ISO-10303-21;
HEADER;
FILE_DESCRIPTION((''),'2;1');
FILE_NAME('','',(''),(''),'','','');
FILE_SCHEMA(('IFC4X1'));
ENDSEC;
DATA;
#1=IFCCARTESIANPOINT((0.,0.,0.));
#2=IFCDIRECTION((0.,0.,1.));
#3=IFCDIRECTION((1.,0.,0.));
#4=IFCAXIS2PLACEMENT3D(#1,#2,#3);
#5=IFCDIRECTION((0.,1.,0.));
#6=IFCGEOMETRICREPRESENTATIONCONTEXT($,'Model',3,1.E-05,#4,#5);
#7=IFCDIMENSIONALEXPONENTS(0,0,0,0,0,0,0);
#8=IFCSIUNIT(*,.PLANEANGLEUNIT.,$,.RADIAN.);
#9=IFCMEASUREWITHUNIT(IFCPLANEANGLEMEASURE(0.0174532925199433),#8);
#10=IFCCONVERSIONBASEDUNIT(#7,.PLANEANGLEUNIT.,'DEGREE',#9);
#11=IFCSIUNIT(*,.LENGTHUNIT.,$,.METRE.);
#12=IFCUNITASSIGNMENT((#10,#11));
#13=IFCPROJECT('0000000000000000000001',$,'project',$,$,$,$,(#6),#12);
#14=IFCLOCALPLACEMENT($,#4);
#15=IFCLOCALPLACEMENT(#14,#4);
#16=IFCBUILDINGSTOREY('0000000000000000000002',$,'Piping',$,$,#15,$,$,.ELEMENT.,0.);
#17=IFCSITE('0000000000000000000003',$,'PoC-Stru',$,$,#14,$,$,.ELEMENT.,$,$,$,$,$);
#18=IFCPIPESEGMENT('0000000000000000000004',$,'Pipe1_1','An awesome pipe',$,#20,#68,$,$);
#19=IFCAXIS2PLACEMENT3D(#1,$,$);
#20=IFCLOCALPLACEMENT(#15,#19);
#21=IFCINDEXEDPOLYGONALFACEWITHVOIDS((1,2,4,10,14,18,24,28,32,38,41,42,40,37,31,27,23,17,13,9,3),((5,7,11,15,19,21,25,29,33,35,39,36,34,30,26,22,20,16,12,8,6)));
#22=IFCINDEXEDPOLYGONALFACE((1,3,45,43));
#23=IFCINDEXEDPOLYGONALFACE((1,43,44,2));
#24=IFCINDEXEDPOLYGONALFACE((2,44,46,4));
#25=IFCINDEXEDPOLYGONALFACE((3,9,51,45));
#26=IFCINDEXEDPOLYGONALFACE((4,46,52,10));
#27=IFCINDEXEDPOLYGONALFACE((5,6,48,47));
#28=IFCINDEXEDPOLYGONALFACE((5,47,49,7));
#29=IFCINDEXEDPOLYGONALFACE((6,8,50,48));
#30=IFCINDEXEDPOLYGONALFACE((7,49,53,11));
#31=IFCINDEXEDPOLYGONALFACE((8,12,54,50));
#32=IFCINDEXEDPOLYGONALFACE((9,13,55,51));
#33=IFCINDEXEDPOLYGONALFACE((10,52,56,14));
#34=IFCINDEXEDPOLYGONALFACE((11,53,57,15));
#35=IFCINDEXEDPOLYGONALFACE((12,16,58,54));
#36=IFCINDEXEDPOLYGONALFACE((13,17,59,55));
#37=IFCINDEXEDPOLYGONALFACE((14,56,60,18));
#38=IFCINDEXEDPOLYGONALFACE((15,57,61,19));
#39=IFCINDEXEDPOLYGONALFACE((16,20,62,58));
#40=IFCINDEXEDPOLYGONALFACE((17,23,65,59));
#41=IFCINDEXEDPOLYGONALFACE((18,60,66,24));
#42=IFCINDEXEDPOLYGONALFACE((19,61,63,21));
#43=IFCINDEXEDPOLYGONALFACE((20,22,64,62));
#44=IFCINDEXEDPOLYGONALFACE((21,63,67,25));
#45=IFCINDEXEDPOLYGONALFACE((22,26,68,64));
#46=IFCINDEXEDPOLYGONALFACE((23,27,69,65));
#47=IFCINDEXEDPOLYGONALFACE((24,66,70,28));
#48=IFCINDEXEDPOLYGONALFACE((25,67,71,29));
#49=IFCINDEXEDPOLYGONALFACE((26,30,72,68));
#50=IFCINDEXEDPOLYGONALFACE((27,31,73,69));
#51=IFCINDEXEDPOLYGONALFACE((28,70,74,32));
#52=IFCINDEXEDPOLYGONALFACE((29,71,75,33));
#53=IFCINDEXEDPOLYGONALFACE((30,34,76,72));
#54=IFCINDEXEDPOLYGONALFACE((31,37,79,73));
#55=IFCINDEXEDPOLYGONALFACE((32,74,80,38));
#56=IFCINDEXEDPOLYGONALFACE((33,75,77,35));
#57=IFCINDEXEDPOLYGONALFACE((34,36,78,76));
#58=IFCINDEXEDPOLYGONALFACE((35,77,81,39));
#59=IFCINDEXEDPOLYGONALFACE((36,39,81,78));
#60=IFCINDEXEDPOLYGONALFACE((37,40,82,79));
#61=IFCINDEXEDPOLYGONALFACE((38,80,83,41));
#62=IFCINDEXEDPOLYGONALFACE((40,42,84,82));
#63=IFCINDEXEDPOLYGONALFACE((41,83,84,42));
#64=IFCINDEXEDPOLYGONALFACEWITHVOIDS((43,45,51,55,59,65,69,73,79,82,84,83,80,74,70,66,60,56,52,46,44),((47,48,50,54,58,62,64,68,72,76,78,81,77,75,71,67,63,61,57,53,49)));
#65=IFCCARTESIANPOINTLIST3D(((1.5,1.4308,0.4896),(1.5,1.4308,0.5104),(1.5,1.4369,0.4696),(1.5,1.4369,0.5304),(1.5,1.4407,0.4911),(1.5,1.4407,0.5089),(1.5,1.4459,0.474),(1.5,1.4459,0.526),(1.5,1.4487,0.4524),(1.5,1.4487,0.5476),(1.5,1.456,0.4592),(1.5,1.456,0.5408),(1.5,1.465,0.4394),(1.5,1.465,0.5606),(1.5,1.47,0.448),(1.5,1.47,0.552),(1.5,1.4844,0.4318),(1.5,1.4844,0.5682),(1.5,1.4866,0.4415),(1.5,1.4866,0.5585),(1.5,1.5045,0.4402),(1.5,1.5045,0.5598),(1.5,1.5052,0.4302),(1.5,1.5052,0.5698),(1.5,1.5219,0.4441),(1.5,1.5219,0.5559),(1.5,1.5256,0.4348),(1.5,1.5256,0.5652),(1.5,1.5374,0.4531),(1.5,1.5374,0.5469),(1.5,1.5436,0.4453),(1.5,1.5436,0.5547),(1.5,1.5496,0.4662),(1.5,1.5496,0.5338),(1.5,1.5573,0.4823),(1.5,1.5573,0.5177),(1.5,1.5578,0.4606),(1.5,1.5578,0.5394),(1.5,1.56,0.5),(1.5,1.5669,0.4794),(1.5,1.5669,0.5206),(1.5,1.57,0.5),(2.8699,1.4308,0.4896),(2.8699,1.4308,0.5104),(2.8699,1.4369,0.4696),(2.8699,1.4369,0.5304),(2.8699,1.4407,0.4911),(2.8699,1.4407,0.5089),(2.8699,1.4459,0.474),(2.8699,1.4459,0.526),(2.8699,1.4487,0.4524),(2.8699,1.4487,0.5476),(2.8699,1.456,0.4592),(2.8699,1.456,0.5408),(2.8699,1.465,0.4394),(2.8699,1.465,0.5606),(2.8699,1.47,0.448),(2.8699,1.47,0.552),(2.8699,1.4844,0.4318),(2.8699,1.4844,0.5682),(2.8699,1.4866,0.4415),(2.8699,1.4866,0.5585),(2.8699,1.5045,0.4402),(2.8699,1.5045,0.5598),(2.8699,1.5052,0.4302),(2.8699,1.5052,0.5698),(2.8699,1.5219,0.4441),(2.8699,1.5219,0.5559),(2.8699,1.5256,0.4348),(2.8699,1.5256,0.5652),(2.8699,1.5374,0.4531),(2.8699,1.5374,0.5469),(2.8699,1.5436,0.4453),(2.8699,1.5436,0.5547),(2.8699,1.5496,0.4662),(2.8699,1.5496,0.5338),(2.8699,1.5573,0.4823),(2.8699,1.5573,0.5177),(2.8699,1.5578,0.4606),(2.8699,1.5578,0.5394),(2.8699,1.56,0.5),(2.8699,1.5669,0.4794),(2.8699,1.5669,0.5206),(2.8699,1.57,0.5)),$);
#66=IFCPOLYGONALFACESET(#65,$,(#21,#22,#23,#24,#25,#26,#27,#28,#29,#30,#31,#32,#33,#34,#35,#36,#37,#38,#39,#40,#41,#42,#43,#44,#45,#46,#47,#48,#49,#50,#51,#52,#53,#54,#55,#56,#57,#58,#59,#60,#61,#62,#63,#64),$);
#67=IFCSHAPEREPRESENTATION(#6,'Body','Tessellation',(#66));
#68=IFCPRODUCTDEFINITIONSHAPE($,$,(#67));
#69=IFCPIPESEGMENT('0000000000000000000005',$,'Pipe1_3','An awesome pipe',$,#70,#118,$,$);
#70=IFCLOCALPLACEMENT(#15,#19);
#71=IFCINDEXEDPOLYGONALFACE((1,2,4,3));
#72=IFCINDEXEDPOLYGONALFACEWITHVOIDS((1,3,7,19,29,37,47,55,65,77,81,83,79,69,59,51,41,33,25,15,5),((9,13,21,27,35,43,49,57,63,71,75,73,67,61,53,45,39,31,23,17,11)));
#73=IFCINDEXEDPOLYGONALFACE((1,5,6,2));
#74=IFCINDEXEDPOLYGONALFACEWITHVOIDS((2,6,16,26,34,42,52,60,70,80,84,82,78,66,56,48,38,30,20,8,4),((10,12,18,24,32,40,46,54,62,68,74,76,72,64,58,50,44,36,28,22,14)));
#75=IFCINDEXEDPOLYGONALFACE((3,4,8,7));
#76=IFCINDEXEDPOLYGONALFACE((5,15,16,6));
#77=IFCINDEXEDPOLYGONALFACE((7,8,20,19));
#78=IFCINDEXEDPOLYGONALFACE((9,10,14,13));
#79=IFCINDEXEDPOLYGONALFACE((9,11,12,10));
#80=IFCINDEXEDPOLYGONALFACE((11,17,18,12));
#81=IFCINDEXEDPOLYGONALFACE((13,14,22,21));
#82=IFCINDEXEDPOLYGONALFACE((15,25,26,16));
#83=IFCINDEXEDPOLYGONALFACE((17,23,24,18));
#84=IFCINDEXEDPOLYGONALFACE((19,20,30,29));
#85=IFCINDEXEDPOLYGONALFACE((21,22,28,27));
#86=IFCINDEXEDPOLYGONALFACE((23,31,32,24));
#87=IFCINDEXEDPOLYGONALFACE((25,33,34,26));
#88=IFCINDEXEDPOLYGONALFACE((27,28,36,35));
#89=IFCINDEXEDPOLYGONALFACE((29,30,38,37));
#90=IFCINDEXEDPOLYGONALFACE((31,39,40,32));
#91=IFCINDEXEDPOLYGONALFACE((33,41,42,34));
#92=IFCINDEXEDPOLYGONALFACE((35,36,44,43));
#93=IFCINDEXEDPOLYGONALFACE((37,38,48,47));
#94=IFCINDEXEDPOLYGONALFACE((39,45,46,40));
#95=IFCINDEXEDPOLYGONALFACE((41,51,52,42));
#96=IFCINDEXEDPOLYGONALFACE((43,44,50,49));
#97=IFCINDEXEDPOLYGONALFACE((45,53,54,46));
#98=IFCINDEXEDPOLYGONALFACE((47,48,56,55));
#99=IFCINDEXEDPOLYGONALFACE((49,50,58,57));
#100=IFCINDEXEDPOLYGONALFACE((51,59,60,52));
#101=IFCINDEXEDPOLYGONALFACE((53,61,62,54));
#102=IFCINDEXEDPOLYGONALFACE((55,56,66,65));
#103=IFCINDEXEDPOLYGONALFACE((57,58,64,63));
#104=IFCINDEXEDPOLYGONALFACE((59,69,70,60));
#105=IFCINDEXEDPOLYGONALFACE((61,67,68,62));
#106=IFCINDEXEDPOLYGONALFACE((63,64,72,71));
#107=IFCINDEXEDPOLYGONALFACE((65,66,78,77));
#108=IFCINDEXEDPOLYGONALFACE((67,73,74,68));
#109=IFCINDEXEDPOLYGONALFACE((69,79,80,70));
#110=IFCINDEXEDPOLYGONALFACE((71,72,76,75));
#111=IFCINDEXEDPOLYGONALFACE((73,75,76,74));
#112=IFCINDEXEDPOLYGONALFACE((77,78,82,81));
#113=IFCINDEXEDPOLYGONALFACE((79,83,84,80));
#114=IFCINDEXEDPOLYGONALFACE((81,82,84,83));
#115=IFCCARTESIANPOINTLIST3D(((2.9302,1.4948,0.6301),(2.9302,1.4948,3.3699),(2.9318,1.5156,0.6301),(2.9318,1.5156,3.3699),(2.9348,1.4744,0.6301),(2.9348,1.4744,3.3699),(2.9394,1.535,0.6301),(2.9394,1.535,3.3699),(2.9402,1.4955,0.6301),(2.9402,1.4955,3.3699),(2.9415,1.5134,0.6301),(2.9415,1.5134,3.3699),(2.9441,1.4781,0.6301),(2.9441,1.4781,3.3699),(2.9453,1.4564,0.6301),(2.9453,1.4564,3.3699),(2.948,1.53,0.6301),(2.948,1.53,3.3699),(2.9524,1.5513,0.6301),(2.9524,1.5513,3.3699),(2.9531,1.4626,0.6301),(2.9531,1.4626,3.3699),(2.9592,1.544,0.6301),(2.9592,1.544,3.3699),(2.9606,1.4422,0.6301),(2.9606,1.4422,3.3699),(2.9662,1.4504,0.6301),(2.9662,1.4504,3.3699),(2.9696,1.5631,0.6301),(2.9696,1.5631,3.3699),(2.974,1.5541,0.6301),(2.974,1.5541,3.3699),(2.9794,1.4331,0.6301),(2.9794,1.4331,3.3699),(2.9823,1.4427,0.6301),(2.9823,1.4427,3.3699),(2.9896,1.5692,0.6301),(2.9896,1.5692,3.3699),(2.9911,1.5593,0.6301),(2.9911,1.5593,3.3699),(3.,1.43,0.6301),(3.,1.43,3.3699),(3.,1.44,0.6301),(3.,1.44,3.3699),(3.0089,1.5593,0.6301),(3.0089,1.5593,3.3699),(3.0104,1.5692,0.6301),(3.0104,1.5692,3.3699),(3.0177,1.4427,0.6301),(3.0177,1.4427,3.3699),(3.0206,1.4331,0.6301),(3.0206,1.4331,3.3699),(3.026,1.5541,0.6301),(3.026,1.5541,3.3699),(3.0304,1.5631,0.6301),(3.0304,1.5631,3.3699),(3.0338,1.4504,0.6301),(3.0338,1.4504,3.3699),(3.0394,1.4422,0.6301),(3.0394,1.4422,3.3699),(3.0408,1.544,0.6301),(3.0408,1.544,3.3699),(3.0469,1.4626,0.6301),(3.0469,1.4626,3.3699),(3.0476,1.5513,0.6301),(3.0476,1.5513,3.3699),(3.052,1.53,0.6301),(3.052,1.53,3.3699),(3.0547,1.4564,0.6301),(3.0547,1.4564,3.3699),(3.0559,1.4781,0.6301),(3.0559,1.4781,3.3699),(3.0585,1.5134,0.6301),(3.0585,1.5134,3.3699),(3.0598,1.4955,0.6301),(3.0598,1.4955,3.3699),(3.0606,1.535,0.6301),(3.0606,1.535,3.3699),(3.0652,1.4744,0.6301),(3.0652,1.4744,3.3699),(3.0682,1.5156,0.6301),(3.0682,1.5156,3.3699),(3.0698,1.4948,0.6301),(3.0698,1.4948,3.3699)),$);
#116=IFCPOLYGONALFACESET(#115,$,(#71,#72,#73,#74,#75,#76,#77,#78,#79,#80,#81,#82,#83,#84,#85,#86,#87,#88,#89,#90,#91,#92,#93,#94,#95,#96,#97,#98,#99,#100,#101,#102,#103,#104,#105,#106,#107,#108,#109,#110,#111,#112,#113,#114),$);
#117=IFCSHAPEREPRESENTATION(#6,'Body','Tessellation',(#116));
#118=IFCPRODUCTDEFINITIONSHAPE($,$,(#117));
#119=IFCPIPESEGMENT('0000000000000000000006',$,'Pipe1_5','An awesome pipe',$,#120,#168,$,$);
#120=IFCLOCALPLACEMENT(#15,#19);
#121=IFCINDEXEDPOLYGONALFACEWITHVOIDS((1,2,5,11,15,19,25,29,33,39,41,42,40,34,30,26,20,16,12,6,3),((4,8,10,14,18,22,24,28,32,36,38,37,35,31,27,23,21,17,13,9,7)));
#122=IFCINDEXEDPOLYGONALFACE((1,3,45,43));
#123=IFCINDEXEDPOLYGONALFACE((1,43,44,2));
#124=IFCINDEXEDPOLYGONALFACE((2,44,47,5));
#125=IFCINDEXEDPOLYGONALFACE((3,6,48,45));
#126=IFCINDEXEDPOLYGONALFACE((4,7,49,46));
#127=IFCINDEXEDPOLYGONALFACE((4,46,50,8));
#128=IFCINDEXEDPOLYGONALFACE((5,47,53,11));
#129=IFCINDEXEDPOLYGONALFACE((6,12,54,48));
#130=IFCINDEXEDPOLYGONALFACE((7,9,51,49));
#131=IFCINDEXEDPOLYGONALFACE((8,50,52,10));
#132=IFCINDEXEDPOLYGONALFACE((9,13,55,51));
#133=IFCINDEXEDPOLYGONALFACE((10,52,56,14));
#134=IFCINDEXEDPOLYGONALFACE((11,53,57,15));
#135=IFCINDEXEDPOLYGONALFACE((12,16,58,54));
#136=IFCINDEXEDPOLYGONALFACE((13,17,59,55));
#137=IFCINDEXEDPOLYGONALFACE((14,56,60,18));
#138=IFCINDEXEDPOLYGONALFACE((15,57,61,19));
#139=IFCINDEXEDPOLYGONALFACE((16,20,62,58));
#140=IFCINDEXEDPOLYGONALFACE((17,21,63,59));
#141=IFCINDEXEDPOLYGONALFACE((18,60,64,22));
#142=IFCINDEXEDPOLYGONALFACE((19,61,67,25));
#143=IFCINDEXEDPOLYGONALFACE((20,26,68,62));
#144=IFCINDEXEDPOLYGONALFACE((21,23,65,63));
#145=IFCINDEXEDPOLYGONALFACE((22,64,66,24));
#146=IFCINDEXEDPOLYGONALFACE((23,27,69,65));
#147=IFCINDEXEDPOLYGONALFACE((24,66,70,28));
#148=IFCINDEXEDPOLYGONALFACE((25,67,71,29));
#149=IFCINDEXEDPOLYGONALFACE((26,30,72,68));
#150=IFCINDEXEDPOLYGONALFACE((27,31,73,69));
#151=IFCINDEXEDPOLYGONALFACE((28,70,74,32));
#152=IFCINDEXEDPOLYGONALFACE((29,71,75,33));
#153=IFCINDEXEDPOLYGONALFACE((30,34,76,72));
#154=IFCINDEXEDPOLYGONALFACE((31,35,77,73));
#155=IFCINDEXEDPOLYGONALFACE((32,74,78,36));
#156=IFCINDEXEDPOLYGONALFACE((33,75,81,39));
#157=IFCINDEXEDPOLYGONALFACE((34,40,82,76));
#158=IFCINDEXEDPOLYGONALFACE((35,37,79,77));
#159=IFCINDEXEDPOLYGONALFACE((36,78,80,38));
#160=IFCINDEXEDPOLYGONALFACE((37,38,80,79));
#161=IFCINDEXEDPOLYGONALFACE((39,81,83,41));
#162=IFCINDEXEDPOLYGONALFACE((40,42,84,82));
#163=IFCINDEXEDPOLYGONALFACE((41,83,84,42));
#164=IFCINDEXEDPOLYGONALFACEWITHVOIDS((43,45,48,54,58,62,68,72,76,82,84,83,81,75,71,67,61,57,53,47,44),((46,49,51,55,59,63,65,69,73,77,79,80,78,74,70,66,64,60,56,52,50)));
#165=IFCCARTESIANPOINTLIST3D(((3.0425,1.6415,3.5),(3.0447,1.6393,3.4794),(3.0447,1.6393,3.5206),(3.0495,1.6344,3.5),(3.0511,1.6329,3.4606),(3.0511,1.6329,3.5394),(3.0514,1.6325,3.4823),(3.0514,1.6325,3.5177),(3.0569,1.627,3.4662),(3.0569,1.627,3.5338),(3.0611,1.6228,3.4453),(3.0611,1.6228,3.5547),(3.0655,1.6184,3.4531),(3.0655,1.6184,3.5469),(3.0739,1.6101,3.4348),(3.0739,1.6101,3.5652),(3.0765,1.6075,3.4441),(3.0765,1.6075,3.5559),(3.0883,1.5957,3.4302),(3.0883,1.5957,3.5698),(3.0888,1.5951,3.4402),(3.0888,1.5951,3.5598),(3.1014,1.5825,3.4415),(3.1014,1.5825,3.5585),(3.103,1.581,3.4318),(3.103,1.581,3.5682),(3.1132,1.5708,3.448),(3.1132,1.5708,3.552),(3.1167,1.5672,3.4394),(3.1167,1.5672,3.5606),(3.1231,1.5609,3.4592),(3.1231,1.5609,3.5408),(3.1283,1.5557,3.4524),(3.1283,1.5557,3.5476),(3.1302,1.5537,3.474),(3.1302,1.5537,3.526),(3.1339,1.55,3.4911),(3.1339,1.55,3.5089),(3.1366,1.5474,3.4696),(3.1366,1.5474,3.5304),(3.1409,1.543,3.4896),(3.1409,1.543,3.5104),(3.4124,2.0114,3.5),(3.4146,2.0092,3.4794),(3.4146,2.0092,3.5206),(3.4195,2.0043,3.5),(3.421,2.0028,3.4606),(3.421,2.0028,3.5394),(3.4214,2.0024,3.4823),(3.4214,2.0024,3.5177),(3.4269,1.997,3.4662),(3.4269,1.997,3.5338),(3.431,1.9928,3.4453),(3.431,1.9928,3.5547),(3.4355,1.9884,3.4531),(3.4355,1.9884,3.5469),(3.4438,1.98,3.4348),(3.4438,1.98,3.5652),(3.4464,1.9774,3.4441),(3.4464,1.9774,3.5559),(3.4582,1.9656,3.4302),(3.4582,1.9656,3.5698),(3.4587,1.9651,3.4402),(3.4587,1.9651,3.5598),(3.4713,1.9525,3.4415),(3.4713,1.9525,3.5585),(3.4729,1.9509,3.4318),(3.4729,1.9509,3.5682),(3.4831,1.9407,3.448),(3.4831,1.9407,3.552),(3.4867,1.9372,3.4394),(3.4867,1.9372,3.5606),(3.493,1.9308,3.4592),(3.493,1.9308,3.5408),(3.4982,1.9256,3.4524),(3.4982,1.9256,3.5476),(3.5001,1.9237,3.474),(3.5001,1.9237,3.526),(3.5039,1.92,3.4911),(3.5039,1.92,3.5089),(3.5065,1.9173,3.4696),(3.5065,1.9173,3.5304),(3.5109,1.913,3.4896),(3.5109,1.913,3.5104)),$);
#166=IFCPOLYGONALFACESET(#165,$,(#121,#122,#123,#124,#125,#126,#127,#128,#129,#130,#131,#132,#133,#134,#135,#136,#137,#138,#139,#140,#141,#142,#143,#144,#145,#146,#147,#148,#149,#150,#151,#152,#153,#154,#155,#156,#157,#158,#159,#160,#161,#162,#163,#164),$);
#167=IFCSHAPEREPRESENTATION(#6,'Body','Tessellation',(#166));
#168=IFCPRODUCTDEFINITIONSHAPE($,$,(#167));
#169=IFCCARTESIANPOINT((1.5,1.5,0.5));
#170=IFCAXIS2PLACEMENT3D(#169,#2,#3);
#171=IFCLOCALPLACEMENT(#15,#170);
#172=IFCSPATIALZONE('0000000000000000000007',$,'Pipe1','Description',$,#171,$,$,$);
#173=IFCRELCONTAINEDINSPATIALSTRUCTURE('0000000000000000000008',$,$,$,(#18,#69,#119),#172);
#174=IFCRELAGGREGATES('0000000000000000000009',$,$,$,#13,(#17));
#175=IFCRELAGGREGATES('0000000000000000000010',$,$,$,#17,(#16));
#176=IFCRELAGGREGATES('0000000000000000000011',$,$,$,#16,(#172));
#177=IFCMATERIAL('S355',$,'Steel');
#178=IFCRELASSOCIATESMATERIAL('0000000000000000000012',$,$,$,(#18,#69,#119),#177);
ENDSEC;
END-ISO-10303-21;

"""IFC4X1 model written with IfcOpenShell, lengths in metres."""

from ifc_helpers import new_model, entity, si_unit, converted_unit, direction, frame, origin_with_axes, place, context, project, spatial, hollow_circle, extrude, material, element, save


model = new_model("IFC4X1")

# Units and contexts
model_context = context("Model", 3, precision=1e-05, world=origin_with_axes(), true_north=direction((0.0, 1.0, 0.0)))
ifc_project = project(units=[converted_unit("PLANEANGLEUNIT", "DEGREE", entity("IfcPlaneAngleMeasure", 0.0174532925199433), si_unit("PLANEANGLEUNIT", "RADIAN"), dimensions=[0, 0, 0, 0, 0, 0, 0]), si_unit("LENGTHUNIT", "METRE")], contexts=[model_context])

# Site, storey, spatial zone
site_placement = place(None, origin_with_axes())
site = spatial("IfcSite", under=ifc_project, at=site_placement, Name="PoC-Stru", CompositionType="ELEMENT")
storey_placement = place(site_placement, origin_with_axes())
storey = spatial("IfcBuildingStorey", under=site, at=storey_placement, Name="Piping", CompositionType="ELEMENT", Elevation=0.0)
spatial_zone_placement = place(storey_placement, frame((1.5, 1.5, 0.5), z_axis=(0.0, 0.0, 1.0), x_axis=(1.0, 0.0, 0.0)))
spatial_zone = spatial("IfcSpatialZone", under=storey, at=spatial_zone_placement, Name="Pipe1", Description="Description")

# Pipe segment
ifc_material = material(Name="S355", Category="Steel")
placement_1 = place(None, origin_with_axes())
pipe_segment_1_placement = place(placement_1, frame((1.5, 1.5, 0.5), z_axis=(1.0, 0.0, 0.0), x_axis=(0.0, 1.0, 0.0)))
element("IfcPipeSegment", 1, at=pipe_segment_1_placement, inside=spatial_zone, material=ifc_material, Name="Pipe1_1", Description="An awesome pipe", context=model_context, shape_type="SweptSolid", body=[
    extrude(hollow_circle(Radius=0.07, WallThickness=0.01), origin_with_axes(), (0.0, 0.0, 1.0), 1.3699),
])

# Pipe segment
placement_2 = place(None, origin_with_axes())
pipe_segment_2_placement = place(placement_2, frame((3.0, 1.5, 0.6301), z_axis=(0.0, 0.0, 1.0), x_axis=(0.0, -1.0, 0.0)))
element("IfcPipeSegment", 2, at=pipe_segment_2_placement, inside=spatial_zone, material=ifc_material, Name="Pipe1_3", Description="An awesome pipe", context=model_context, shape_type="SweptSolid", body=[
    extrude(hollow_circle(Radius=0.07, WallThickness=0.01), origin_with_axes(), (0.0, 0.0, 1.0), 2.7399),
])

# Pipe segment
placement_3 = place(None, origin_with_axes())
pipe_segment_3_placement = place(placement_3, frame((3.092, 1.592, 3.5), z_axis=(0.707107, 0.707107, 0.0), x_axis=(-0.707107, 0.707107, 0.0)))
element("IfcPipeSegment", 3, at=pipe_segment_3_placement, inside=spatial_zone, material=ifc_material, Name="Pipe1_5", Description="An awesome pipe", context=model_context, shape_type="SweptSolid", body=[
    extrude(hollow_circle(Radius=0.07, WallThickness=0.01), origin_with_axes(), (0.0, 0.0, 1.0), 0.5232),
])

save(model, "model.ifc")
